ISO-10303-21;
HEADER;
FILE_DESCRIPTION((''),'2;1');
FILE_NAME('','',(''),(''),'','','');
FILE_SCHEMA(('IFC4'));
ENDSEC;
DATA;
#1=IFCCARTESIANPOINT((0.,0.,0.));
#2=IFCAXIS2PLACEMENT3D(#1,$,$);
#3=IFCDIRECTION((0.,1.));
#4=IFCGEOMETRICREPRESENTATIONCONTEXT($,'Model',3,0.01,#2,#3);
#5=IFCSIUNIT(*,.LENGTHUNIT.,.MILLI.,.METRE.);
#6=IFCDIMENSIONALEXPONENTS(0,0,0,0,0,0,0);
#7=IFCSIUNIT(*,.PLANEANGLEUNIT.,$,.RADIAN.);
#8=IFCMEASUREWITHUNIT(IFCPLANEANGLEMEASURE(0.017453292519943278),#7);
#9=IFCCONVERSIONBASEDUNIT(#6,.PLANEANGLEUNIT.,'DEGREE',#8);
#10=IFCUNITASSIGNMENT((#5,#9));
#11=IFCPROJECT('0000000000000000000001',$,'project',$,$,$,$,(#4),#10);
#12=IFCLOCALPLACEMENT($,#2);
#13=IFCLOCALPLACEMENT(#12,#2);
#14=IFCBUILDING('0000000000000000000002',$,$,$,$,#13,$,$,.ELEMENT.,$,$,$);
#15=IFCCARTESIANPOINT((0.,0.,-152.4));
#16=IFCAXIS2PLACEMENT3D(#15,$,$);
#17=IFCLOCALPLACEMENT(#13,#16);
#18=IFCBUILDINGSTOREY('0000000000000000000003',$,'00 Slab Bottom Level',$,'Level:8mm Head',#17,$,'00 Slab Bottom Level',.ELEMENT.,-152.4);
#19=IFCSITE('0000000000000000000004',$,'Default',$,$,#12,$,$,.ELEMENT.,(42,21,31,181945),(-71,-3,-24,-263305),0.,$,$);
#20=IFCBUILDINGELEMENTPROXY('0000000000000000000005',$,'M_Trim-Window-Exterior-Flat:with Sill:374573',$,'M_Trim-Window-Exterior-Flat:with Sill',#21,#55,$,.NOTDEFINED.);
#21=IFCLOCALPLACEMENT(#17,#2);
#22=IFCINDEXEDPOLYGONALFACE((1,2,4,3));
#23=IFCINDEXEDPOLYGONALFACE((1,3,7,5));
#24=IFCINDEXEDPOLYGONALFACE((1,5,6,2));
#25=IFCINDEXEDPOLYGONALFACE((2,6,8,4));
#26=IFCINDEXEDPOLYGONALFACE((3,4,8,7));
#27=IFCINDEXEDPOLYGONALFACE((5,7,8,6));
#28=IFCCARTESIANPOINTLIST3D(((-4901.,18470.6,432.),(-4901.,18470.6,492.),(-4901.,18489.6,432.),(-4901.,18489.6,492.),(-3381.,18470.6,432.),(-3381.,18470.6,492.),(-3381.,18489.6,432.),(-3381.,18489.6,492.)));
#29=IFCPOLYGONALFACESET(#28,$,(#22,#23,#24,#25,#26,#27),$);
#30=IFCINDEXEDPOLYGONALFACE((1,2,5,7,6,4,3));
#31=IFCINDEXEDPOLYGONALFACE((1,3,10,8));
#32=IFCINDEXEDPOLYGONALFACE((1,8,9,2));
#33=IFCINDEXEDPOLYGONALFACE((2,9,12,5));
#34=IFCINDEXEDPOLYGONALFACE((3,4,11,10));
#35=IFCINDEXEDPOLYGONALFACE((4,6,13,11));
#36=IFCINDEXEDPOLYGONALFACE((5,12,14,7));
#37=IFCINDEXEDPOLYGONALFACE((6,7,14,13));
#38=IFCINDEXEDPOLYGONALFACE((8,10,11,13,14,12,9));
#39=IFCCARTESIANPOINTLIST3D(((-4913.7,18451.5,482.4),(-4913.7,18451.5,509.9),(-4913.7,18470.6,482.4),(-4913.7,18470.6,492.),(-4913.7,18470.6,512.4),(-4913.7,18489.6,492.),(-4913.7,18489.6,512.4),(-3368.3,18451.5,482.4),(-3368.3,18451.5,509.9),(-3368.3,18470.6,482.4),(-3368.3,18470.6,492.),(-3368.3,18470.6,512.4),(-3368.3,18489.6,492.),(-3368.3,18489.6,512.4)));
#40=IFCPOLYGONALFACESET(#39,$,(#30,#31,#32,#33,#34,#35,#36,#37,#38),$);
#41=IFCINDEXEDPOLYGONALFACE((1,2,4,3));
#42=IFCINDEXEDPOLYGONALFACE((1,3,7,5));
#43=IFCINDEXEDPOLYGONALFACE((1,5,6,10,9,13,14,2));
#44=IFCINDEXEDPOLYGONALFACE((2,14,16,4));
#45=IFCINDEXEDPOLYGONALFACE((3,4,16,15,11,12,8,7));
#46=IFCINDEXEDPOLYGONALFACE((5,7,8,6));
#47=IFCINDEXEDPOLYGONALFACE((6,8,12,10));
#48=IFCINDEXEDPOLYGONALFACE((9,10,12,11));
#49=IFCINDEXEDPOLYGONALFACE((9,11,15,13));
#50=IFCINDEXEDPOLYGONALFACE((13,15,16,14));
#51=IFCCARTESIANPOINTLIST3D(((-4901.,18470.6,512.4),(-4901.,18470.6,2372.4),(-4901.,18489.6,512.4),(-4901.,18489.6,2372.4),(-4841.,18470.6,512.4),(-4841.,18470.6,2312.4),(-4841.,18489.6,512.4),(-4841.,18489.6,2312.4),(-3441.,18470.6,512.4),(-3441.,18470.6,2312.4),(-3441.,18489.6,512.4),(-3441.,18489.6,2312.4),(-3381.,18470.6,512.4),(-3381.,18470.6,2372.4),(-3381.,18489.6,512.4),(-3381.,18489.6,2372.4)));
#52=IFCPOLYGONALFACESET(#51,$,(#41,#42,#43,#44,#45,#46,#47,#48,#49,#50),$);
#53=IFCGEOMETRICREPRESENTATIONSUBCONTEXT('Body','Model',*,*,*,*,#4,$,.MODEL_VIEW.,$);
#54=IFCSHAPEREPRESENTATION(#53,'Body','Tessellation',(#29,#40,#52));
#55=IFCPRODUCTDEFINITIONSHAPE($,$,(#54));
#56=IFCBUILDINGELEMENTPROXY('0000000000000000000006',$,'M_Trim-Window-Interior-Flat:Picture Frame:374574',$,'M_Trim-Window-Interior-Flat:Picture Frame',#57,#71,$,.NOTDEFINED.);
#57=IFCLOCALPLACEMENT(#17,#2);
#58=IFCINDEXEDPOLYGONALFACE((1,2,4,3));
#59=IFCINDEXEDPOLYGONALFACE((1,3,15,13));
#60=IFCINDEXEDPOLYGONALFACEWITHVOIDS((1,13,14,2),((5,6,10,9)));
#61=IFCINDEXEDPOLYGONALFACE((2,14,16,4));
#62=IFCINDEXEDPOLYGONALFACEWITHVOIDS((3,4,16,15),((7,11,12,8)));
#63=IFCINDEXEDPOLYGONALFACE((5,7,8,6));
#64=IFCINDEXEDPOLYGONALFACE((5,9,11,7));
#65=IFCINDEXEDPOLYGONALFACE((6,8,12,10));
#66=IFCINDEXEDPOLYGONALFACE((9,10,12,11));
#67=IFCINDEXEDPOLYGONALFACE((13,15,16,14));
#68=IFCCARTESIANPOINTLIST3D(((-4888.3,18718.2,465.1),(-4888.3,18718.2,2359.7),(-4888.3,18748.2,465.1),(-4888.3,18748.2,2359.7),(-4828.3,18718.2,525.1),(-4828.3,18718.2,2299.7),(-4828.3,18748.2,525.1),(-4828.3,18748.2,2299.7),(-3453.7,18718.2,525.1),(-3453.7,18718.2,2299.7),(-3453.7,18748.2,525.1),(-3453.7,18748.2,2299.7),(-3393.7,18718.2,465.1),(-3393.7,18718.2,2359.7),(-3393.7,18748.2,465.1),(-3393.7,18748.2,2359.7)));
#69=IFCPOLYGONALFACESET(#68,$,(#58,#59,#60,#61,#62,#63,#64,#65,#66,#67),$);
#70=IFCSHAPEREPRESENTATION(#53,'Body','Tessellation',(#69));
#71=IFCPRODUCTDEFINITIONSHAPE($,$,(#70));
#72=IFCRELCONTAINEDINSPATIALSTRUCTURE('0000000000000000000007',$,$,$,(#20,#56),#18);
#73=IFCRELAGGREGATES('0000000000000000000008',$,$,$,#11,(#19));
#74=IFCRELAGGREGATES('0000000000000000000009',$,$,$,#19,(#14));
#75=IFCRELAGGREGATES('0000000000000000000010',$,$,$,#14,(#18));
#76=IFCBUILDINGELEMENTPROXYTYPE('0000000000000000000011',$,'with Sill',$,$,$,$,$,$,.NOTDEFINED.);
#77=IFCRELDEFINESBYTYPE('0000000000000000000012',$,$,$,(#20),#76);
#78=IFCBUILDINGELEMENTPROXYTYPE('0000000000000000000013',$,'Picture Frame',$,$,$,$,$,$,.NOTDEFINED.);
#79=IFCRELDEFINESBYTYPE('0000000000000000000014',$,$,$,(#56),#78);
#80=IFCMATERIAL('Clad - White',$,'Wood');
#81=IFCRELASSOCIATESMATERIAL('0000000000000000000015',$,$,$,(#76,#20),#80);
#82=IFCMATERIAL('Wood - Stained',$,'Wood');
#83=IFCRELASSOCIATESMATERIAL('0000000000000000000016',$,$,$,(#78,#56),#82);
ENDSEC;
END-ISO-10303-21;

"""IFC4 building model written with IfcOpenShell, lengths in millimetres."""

from ifc_helpers import new_model, entity, si_unit, converted_unit, direction, frame, origin, place, context, subcontext, project, spatial, indexed_curve, outline, extrude, source, transform, mapped, material, type_object, type_shapes, element, save


model = new_model("IFC4")

# Units and contexts
model_context = context("Model", 3, precision=0.01, world=origin(), true_north=direction((0.0, 1.0)))
body_context = subcontext(model_context, "Body", "Model", "MODEL_VIEW")
ifc_project = project(units=[si_unit("LENGTHUNIT", "METRE", prefix="MILLI"), converted_unit("PLANEANGLEUNIT", "DEGREE", entity("IfcPlaneAngleMeasure", 0.017453292519943278), si_unit("PLANEANGLEUNIT", "RADIAN"), dimensions=[0, 0, 0, 0, 0, 0, 0])], contexts=[model_context])

# Site, building, storey
site_placement = place(None, origin())
site = spatial("IfcSite", under=ifc_project, at=site_placement, Name="Default", CompositionType="ELEMENT", RefLatitude=(42, 21, 31, 181945), RefLongitude=(-71, -3, -24, -263305), RefElevation=0.0)
building_placement = place(site_placement, origin())
building = spatial("IfcBuilding", under=site, at=building_placement, CompositionType="ELEMENT")
storey_placement = place(building_placement, frame((0.0, 0.0, -152.4)))
storey = spatial("IfcBuildingStorey", under=building, at=storey_placement, Name="00 Slab Bottom Level", ObjectType="Level:8mm Head", LongName="00 Slab Bottom Level", CompositionType="ELEMENT", Elevation=-152.4)

# Building element proxies
ifc_material_1 = material(Name="Clad - White", Category="Wood")
ifc_material_2 = material(Name="Wood - Stained", Category="Wood")
building_element_proxy_type_1 = type_object("IfcBuildingElementProxyType", Name="with Sill", PredefinedType="NOTDEFINED", material=ifc_material_1)
shared_shape_1 = source(origin(), body_context, "Body", "SweptSolid", [
    extrude(outline(indexed_curve([(-30.0, -760.0), (30.0, -760.0), (30.0, 760.0), (-30.0, 760.0), (-30.0, -760.0)], self_intersect=False)), frame((0.0, 1850.4, 0.0), z_axis=(0.0, 0.0, 1.0), x_axis=(0.0, 1.0, 0.0)), (0.0, 0.0, 1.0), 19.0),
    extrude(outline(indexed_curve([(-15.2, -19.0), (12.3, -19.0), (14.8, 0.0), (14.8, 19.0), (-5.7, 19.0), (-5.7, 0.0), (-15.2, 0.0), (-15.2, -19.0)], self_intersect=False)), frame((-772.7, 1814.8, 19.0), z_axis=(1.0, 0.0, 0.0), x_axis=(0.0, -1.0, 0.0)), (0.0, 0.0, 1.0), 1545.4),
    extrude(outline(indexed_curve([(-760.0, -945.0), (760.0, -945.0), (760.0, 915.0), (700.0, 915.0), (700.0, -885.0), (-700.0, -885.0), (-700.0, 915.0), (-760.0, 915.0), (-760.0, -945.0)], self_intersect=False)), frame((0.0, 885.0, 0.0)), (0.0, 0.0, 1.0), 19.0),
])
type_shapes(building_element_proxy_type_1, [shared_shape_1])
proxy_1_placement = place(storey_placement, frame((-4141.0, 18489.6, 2312.4), z_axis=(0.0, -1.0, 0.0), x_axis=(-1.0, 0.0, 0.0)))
element("IfcBuildingElementProxy", 1, at=proxy_1_placement, inside=storey, type_object=building_element_proxy_type_1, material=ifc_material_1, Name="M_Trim-Window-Exterior-Flat:with Sill:374573", ObjectType="M_Trim-Window-Exterior-Flat:with Sill", PredefinedType="NOTDEFINED", context=body_context, shape_type="MappedRepresentation", body=[
    mapped(shared_shape_1, transform((0.0, 0.0, 0.0), scale=1.0)),
])
building_element_proxy_type_2 = type_object("IfcBuildingElementProxyType", Name="Picture Frame", PredefinedType="NOTDEFINED", material=ifc_material_2)
shared_shape_2 = source(origin(), body_context, "Body", "SweptSolid", [
    extrude(outline(indexed_curve([(-947.3, -747.3), (947.3, -747.3), (947.3, 747.3), (-947.3, 747.3), (-947.3, -747.3)], self_intersect=False), holes=[indexed_curve([(-887.3, -687.3), (-887.3, 687.3), (887.3, 687.3), (887.3, -687.3), (-887.3, -687.3)], self_intersect=False)]), frame((0.0, 900.0, 0.0), z_axis=(0.0, 0.0, 1.0), x_axis=(0.0, 1.0, 0.0)), (0.0, 0.0, 1.0), 30.0),
])
type_shapes(building_element_proxy_type_2, [shared_shape_2])
proxy_2_placement = place(storey_placement, frame((-4141.0, 18718.2, 2312.4), z_axis=(0.0, 1.0, 0.0), x_axis=(1.0, 0.0, 0.0)))
element("IfcBuildingElementProxy", 2, at=proxy_2_placement, inside=storey, type_object=building_element_proxy_type_2, material=ifc_material_2, Name="M_Trim-Window-Interior-Flat:Picture Frame:374574", ObjectType="M_Trim-Window-Interior-Flat:Picture Frame", PredefinedType="NOTDEFINED", context=body_context, shape_type="MappedRepresentation", body=[
    mapped(shared_shape_2, transform((0.0, 0.0, 0.0), scale=1.0)),
])

save(model, "model.ifc")
